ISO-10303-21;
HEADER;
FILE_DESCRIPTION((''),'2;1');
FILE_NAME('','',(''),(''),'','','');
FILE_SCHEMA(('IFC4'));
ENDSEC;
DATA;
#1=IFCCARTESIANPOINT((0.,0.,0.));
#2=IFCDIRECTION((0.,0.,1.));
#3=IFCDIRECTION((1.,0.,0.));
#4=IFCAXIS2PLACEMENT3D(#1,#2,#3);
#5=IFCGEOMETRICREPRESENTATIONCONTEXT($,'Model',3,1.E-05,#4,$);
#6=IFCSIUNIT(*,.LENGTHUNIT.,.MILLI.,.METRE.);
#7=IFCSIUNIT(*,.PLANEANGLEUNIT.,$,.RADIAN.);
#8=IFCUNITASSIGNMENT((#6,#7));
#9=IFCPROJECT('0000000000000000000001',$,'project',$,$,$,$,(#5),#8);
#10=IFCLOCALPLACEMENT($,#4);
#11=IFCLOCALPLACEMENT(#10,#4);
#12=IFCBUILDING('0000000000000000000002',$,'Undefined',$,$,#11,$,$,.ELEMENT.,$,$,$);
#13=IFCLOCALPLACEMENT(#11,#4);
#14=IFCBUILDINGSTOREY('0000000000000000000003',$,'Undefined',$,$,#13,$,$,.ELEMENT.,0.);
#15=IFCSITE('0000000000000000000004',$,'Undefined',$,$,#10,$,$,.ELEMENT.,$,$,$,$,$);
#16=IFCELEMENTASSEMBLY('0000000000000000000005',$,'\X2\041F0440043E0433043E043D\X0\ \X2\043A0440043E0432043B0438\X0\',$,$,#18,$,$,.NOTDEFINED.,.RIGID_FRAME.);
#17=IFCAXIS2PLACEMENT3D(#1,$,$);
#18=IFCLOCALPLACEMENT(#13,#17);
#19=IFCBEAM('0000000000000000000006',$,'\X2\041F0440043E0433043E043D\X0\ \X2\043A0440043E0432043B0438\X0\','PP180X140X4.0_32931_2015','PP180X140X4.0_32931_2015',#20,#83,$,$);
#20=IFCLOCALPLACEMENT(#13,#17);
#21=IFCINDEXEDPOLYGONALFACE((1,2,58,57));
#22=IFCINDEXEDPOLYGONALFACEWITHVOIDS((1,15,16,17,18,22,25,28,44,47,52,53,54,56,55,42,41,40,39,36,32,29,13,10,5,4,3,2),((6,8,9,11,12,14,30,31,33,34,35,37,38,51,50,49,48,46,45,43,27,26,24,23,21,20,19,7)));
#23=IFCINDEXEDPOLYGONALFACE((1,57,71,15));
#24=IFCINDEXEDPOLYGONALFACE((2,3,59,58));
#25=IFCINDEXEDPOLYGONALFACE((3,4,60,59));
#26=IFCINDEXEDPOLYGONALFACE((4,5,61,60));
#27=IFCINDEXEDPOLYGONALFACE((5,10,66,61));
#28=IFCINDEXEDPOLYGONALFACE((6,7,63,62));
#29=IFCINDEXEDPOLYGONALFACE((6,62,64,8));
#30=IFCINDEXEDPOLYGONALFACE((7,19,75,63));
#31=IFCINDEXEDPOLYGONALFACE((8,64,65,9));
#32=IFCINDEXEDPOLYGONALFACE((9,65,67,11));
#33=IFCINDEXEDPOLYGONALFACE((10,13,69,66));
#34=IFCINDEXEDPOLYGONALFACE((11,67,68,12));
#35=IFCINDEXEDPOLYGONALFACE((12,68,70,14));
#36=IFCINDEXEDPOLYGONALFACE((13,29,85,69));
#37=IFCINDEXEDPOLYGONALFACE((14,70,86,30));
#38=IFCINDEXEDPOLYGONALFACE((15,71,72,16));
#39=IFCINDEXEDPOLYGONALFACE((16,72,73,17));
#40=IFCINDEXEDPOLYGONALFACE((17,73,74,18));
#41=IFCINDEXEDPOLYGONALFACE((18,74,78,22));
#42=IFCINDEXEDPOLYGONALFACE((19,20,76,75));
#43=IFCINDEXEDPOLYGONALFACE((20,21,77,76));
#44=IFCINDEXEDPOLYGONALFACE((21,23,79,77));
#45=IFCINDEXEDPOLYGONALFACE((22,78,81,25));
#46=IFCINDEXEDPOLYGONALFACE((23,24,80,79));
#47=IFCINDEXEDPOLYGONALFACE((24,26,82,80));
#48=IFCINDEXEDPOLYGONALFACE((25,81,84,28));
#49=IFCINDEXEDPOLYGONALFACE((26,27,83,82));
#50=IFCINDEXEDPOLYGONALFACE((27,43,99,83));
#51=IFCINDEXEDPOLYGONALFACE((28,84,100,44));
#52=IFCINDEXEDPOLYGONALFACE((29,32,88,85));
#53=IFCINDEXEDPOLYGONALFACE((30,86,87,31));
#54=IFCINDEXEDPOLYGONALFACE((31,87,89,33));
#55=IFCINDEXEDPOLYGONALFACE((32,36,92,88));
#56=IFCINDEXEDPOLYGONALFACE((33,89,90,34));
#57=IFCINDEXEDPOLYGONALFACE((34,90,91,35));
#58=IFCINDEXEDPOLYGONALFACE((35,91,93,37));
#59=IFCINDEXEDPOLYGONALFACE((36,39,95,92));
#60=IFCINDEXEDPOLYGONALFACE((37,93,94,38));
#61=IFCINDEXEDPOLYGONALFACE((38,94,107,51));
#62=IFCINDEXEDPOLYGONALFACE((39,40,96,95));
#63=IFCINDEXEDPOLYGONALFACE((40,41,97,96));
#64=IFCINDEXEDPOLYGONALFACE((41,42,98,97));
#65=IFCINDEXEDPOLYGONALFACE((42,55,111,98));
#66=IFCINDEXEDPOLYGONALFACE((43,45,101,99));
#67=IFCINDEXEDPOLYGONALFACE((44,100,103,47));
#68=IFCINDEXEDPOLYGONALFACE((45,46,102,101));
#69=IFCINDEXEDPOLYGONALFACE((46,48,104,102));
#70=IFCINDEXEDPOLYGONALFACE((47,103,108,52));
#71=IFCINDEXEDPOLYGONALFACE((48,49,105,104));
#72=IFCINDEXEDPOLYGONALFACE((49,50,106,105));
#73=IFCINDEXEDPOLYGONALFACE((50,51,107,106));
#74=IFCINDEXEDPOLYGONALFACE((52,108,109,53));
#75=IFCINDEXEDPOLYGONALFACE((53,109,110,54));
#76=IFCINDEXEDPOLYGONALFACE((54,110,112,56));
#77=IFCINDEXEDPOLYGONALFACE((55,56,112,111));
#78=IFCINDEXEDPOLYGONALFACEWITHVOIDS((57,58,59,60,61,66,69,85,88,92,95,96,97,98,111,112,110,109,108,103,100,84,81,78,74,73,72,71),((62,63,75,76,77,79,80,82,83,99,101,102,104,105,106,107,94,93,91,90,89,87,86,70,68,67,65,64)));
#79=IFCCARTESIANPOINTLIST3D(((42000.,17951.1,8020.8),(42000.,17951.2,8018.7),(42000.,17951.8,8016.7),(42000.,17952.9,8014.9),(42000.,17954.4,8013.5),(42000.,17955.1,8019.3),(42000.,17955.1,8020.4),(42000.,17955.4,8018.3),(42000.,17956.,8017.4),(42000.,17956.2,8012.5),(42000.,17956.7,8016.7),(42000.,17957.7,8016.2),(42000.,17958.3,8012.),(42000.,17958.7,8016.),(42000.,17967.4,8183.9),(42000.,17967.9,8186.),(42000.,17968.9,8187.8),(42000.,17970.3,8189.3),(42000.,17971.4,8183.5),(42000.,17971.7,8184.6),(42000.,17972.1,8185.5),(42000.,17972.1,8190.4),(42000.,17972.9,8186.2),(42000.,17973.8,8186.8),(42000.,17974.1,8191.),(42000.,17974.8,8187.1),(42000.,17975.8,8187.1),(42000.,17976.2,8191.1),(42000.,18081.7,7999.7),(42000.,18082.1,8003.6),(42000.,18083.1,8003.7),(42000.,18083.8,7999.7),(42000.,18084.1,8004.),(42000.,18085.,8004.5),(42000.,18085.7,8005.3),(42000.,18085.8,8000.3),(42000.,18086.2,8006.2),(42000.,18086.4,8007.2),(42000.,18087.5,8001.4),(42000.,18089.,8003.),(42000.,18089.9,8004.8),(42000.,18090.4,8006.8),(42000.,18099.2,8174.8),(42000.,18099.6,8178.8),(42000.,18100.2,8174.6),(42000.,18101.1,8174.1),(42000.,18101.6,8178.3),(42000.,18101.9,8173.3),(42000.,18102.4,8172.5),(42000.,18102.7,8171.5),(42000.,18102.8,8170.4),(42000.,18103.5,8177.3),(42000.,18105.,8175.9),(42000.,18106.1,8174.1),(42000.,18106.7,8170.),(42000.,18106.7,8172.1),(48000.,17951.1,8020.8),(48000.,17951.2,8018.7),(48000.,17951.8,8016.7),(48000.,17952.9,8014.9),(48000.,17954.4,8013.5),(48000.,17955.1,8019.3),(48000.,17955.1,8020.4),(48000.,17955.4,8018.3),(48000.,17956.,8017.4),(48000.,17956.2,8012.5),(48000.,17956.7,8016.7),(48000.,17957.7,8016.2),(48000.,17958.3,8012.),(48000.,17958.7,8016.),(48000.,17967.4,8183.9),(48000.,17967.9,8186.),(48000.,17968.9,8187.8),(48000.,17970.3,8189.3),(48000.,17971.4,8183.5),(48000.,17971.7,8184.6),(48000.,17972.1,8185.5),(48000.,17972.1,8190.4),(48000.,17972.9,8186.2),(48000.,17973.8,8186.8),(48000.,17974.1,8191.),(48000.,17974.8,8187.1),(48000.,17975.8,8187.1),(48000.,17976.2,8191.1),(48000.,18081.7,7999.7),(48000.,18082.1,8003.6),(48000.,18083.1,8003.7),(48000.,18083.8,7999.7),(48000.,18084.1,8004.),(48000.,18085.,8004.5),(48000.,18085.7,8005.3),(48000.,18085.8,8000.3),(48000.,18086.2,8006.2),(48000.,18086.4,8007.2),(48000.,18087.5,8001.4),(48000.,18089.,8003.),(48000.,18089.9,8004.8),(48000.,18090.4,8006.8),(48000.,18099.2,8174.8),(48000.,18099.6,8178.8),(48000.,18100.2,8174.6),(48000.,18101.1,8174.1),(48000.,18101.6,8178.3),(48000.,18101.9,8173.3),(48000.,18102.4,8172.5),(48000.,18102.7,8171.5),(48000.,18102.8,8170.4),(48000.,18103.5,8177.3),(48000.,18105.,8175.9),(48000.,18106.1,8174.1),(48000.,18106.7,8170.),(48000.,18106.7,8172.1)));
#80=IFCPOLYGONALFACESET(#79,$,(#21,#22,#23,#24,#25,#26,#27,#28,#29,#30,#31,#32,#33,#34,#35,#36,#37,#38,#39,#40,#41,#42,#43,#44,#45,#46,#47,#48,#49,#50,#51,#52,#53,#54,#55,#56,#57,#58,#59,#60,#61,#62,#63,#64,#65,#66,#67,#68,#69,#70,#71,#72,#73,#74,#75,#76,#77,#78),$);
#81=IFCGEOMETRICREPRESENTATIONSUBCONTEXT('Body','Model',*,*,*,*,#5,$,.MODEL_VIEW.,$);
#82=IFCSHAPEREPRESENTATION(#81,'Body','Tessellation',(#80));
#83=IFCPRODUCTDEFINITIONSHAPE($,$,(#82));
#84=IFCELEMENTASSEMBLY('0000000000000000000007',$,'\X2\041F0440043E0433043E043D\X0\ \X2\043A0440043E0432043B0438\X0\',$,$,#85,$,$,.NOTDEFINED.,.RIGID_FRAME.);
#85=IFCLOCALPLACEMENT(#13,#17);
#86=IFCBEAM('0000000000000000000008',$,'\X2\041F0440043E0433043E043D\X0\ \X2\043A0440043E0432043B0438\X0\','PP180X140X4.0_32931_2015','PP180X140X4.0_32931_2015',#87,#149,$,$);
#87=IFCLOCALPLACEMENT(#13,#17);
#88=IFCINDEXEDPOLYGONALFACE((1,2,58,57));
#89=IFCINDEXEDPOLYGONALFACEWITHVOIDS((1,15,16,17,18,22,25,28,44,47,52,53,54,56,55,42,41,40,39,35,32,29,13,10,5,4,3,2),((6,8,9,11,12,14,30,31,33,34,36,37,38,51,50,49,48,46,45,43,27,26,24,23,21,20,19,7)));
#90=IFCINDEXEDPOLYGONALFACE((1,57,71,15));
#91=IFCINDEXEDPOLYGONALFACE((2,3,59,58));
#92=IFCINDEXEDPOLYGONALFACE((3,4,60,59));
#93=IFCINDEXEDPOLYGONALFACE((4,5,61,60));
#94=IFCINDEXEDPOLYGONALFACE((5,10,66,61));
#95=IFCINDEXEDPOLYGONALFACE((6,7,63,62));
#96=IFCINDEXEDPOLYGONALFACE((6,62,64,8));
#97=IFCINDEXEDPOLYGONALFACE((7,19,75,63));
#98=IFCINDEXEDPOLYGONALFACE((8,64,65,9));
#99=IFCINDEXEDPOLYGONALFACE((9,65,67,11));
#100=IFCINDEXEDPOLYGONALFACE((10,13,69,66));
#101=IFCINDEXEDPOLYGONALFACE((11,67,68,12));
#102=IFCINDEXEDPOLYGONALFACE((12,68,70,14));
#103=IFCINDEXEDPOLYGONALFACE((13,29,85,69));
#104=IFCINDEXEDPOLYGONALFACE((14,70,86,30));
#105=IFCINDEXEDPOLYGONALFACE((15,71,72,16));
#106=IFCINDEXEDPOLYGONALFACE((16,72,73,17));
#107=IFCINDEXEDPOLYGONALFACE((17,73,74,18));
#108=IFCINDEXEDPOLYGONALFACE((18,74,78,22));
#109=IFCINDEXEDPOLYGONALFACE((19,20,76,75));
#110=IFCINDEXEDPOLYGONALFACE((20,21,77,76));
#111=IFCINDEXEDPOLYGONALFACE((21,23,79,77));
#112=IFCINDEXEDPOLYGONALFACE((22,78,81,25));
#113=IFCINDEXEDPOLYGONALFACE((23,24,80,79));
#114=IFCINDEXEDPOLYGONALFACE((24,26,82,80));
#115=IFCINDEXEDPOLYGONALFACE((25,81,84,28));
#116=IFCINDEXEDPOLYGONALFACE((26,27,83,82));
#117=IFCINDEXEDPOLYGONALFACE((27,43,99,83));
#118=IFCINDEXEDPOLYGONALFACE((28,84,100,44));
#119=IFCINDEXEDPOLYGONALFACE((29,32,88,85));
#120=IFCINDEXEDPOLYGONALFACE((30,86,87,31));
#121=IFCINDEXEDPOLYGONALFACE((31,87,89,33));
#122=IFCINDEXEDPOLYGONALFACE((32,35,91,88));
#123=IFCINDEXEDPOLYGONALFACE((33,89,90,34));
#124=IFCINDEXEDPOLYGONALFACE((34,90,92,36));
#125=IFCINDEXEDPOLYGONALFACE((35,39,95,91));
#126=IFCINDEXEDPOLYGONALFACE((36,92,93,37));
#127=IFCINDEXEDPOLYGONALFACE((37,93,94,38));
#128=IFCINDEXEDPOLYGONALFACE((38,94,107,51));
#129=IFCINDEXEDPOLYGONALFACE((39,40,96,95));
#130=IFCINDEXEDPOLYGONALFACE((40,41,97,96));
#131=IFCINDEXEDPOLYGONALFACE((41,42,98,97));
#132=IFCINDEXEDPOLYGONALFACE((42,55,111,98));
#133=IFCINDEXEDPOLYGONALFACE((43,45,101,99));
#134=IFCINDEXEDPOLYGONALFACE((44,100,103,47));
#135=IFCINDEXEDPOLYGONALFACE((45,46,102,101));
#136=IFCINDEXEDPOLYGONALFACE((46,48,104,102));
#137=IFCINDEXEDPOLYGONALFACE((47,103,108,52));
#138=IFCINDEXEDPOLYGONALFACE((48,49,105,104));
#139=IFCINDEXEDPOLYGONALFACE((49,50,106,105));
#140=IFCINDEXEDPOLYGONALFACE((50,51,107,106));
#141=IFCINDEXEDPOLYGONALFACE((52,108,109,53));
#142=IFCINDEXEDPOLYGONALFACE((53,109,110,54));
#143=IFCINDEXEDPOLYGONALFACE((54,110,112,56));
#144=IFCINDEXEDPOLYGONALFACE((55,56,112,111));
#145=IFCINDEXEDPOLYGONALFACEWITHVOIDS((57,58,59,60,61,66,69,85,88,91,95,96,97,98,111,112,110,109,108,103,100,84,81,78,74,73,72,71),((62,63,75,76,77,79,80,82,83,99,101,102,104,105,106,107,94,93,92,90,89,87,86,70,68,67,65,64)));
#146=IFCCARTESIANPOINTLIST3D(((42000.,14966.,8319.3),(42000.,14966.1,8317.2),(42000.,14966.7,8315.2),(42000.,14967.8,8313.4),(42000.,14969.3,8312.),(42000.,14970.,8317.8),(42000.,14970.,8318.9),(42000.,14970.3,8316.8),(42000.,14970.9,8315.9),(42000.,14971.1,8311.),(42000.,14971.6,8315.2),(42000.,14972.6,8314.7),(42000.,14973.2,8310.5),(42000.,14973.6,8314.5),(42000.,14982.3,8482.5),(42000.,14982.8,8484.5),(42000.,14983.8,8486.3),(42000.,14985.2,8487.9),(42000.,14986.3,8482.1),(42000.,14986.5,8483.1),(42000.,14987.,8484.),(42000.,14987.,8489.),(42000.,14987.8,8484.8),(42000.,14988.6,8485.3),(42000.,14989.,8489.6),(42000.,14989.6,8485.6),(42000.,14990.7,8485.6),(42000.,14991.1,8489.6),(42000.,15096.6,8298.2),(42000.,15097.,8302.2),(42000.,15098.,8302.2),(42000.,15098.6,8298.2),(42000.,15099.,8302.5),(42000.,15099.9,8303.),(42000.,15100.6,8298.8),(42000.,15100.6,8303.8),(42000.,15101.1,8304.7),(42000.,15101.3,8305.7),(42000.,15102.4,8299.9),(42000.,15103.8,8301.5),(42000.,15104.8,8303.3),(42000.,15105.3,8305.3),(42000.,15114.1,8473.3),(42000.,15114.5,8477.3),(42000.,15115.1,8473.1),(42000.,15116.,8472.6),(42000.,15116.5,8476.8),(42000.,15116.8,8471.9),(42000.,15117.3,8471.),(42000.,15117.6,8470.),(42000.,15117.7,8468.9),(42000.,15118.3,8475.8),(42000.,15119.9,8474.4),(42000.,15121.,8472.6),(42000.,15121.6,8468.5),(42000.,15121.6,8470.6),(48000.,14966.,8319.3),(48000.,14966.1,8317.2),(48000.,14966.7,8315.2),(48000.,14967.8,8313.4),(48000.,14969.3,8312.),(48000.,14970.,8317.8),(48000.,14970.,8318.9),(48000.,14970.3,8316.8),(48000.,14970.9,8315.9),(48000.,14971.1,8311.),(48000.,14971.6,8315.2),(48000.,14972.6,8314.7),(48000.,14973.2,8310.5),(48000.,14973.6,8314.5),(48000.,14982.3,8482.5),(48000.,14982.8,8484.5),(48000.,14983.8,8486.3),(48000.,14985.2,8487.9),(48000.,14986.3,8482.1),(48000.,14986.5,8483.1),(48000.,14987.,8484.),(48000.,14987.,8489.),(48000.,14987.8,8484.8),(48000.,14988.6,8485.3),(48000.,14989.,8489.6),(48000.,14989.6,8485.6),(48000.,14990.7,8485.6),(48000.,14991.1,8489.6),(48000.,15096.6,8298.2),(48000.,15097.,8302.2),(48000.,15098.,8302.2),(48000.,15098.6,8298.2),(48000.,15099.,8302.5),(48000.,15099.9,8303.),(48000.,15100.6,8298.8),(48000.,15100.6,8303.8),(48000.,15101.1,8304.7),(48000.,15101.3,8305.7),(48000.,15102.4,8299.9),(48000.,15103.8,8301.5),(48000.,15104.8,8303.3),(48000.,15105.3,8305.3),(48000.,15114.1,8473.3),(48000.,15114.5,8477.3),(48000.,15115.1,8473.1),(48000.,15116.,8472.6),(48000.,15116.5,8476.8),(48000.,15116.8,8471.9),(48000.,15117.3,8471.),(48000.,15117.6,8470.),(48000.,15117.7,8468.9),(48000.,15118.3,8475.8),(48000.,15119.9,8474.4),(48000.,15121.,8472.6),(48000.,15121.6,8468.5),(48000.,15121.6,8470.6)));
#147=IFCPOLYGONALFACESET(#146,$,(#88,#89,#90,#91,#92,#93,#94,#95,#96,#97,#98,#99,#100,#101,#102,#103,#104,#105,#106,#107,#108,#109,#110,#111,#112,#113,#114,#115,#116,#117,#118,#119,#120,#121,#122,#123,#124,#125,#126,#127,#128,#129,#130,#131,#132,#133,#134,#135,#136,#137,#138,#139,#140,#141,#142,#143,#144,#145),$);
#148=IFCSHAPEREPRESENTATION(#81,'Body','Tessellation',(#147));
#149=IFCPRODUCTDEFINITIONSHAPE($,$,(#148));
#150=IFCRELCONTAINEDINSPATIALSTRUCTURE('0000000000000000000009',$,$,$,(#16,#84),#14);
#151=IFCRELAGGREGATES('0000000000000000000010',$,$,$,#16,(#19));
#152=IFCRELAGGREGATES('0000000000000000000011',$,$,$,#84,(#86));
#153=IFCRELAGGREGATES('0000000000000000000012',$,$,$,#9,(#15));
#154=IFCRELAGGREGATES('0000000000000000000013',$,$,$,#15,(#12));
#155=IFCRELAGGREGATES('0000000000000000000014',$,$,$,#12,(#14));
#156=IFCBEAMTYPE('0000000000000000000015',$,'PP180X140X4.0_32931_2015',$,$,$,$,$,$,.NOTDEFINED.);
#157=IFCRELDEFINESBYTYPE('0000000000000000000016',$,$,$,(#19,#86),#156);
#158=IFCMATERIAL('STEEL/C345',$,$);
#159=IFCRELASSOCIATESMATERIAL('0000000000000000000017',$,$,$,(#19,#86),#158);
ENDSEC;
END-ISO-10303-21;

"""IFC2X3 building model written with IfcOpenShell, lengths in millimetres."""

from ifc_helpers import new_model, si_unit, frame, origin_with_axes, origin_2d_with_axis, place, context, subcontext, project, spatial, hollow_rectangle, extrude, material, type_object, element, aggregate, save


model = new_model("IFC2X3")

# Units and contexts
model_context = context("Model", 3, precision=1e-05, world=origin_with_axes())
body_context = subcontext(model_context, "Body", "Model", "MODEL_VIEW")
ifc_project = project(units=[si_unit("LENGTHUNIT", "METRE", prefix="MILLI"), si_unit("PLANEANGLEUNIT", "RADIAN")], contexts=[model_context])

# Site, building, storey
site_placement = place(None, origin_with_axes())
site = spatial("IfcSite", under=ifc_project, at=site_placement, Name="Undefined", CompositionType="ELEMENT")
building_placement = place(site_placement, origin_with_axes())
building = spatial("IfcBuilding", under=site, at=building_placement, Name="Undefined", CompositionType="ELEMENT")
storey_placement = place(building_placement, origin_with_axes())
storey = spatial("IfcBuildingStorey", under=building, at=storey_placement, Name="Undefined", CompositionType="ELEMENT", Elevation=0.0)

# Element assemblies, beams
ifc_material_1 = material(Name="STEEL/C345")
beam_type_1 = type_object("IfcBeamType", Name="PP180X140X4.0_32931_2015", PredefinedType="NOTDEFINED")
assembly_1_placement = place(storey_placement, origin_with_axes())
assembly_1 = element("IfcElementAssembly", 1, at=assembly_1_placement, inside=storey, Name="Прогон кровли", AssemblyPlace="NOTDEFINED", PredefinedType="RIGID_FRAME")
beam_1_placement = place(assembly_1_placement, frame((42000.0, 18028.9, 8095.4), z_axis=(0.0, 0.099504, 0.995037), x_axis=(1.0, 0.0, 0.0)))
beam_1 = element("IfcBeam", 2, at=beam_1_placement, type_object=beam_type_1, material=ifc_material_1, Name="Прогон кровли", Description="PP180X140X4.0_32931_2015", ObjectType="PP180X140X4.0_32931_2015", context=body_context, shape_type="SweptSolid", body=[
    extrude(hollow_rectangle(XDim=140.0, YDim=180.0, WallThickness=4.0, InnerFilletRadius=4.0, OuterFilletRadius=8.0, at=origin_2d_with_axis()), frame((6000.0, 0.0, 0.0), z_axis=(-1.0, 0.0, 0.0), x_axis=(0.0, -1.0, 0.0)), (0.0, 0.0, 1.0), 6000.0),
])
aggregate(assembly_1, [beam_1])
assembly_2_placement = place(storey_placement, origin_with_axes())
assembly_2 = element("IfcElementAssembly", 3, at=assembly_2_placement, inside=storey, Name="Прогон кровли", AssemblyPlace="NOTDEFINED", PredefinedType="RIGID_FRAME")
beam_2_placement = place(assembly_2_placement, frame((42000.0, 15043.8, 8393.9), z_axis=(0.0, 0.099504, 0.995037), x_axis=(1.0, 0.0, 0.0)))
beam_2 = element("IfcBeam", 4, at=beam_2_placement, type_object=beam_type_1, material=ifc_material_1, Name="Прогон кровли", Description="PP180X140X4.0_32931_2015", ObjectType="PP180X140X4.0_32931_2015", context=body_context, shape_type="SweptSolid", body=[
    extrude(hollow_rectangle(XDim=140.0, YDim=180.0, WallThickness=4.0, InnerFilletRadius=4.0, OuterFilletRadius=8.0, at=origin_2d_with_axis()), frame((6000.0, 0.0, 0.0), z_axis=(-1.0, 0.0, 0.0), x_axis=(0.0, -1.0, 0.0)), (0.0, 0.0, 1.0), 6000.0),
])
aggregate(assembly_2, [beam_2])

save(model, "model.ifc")
